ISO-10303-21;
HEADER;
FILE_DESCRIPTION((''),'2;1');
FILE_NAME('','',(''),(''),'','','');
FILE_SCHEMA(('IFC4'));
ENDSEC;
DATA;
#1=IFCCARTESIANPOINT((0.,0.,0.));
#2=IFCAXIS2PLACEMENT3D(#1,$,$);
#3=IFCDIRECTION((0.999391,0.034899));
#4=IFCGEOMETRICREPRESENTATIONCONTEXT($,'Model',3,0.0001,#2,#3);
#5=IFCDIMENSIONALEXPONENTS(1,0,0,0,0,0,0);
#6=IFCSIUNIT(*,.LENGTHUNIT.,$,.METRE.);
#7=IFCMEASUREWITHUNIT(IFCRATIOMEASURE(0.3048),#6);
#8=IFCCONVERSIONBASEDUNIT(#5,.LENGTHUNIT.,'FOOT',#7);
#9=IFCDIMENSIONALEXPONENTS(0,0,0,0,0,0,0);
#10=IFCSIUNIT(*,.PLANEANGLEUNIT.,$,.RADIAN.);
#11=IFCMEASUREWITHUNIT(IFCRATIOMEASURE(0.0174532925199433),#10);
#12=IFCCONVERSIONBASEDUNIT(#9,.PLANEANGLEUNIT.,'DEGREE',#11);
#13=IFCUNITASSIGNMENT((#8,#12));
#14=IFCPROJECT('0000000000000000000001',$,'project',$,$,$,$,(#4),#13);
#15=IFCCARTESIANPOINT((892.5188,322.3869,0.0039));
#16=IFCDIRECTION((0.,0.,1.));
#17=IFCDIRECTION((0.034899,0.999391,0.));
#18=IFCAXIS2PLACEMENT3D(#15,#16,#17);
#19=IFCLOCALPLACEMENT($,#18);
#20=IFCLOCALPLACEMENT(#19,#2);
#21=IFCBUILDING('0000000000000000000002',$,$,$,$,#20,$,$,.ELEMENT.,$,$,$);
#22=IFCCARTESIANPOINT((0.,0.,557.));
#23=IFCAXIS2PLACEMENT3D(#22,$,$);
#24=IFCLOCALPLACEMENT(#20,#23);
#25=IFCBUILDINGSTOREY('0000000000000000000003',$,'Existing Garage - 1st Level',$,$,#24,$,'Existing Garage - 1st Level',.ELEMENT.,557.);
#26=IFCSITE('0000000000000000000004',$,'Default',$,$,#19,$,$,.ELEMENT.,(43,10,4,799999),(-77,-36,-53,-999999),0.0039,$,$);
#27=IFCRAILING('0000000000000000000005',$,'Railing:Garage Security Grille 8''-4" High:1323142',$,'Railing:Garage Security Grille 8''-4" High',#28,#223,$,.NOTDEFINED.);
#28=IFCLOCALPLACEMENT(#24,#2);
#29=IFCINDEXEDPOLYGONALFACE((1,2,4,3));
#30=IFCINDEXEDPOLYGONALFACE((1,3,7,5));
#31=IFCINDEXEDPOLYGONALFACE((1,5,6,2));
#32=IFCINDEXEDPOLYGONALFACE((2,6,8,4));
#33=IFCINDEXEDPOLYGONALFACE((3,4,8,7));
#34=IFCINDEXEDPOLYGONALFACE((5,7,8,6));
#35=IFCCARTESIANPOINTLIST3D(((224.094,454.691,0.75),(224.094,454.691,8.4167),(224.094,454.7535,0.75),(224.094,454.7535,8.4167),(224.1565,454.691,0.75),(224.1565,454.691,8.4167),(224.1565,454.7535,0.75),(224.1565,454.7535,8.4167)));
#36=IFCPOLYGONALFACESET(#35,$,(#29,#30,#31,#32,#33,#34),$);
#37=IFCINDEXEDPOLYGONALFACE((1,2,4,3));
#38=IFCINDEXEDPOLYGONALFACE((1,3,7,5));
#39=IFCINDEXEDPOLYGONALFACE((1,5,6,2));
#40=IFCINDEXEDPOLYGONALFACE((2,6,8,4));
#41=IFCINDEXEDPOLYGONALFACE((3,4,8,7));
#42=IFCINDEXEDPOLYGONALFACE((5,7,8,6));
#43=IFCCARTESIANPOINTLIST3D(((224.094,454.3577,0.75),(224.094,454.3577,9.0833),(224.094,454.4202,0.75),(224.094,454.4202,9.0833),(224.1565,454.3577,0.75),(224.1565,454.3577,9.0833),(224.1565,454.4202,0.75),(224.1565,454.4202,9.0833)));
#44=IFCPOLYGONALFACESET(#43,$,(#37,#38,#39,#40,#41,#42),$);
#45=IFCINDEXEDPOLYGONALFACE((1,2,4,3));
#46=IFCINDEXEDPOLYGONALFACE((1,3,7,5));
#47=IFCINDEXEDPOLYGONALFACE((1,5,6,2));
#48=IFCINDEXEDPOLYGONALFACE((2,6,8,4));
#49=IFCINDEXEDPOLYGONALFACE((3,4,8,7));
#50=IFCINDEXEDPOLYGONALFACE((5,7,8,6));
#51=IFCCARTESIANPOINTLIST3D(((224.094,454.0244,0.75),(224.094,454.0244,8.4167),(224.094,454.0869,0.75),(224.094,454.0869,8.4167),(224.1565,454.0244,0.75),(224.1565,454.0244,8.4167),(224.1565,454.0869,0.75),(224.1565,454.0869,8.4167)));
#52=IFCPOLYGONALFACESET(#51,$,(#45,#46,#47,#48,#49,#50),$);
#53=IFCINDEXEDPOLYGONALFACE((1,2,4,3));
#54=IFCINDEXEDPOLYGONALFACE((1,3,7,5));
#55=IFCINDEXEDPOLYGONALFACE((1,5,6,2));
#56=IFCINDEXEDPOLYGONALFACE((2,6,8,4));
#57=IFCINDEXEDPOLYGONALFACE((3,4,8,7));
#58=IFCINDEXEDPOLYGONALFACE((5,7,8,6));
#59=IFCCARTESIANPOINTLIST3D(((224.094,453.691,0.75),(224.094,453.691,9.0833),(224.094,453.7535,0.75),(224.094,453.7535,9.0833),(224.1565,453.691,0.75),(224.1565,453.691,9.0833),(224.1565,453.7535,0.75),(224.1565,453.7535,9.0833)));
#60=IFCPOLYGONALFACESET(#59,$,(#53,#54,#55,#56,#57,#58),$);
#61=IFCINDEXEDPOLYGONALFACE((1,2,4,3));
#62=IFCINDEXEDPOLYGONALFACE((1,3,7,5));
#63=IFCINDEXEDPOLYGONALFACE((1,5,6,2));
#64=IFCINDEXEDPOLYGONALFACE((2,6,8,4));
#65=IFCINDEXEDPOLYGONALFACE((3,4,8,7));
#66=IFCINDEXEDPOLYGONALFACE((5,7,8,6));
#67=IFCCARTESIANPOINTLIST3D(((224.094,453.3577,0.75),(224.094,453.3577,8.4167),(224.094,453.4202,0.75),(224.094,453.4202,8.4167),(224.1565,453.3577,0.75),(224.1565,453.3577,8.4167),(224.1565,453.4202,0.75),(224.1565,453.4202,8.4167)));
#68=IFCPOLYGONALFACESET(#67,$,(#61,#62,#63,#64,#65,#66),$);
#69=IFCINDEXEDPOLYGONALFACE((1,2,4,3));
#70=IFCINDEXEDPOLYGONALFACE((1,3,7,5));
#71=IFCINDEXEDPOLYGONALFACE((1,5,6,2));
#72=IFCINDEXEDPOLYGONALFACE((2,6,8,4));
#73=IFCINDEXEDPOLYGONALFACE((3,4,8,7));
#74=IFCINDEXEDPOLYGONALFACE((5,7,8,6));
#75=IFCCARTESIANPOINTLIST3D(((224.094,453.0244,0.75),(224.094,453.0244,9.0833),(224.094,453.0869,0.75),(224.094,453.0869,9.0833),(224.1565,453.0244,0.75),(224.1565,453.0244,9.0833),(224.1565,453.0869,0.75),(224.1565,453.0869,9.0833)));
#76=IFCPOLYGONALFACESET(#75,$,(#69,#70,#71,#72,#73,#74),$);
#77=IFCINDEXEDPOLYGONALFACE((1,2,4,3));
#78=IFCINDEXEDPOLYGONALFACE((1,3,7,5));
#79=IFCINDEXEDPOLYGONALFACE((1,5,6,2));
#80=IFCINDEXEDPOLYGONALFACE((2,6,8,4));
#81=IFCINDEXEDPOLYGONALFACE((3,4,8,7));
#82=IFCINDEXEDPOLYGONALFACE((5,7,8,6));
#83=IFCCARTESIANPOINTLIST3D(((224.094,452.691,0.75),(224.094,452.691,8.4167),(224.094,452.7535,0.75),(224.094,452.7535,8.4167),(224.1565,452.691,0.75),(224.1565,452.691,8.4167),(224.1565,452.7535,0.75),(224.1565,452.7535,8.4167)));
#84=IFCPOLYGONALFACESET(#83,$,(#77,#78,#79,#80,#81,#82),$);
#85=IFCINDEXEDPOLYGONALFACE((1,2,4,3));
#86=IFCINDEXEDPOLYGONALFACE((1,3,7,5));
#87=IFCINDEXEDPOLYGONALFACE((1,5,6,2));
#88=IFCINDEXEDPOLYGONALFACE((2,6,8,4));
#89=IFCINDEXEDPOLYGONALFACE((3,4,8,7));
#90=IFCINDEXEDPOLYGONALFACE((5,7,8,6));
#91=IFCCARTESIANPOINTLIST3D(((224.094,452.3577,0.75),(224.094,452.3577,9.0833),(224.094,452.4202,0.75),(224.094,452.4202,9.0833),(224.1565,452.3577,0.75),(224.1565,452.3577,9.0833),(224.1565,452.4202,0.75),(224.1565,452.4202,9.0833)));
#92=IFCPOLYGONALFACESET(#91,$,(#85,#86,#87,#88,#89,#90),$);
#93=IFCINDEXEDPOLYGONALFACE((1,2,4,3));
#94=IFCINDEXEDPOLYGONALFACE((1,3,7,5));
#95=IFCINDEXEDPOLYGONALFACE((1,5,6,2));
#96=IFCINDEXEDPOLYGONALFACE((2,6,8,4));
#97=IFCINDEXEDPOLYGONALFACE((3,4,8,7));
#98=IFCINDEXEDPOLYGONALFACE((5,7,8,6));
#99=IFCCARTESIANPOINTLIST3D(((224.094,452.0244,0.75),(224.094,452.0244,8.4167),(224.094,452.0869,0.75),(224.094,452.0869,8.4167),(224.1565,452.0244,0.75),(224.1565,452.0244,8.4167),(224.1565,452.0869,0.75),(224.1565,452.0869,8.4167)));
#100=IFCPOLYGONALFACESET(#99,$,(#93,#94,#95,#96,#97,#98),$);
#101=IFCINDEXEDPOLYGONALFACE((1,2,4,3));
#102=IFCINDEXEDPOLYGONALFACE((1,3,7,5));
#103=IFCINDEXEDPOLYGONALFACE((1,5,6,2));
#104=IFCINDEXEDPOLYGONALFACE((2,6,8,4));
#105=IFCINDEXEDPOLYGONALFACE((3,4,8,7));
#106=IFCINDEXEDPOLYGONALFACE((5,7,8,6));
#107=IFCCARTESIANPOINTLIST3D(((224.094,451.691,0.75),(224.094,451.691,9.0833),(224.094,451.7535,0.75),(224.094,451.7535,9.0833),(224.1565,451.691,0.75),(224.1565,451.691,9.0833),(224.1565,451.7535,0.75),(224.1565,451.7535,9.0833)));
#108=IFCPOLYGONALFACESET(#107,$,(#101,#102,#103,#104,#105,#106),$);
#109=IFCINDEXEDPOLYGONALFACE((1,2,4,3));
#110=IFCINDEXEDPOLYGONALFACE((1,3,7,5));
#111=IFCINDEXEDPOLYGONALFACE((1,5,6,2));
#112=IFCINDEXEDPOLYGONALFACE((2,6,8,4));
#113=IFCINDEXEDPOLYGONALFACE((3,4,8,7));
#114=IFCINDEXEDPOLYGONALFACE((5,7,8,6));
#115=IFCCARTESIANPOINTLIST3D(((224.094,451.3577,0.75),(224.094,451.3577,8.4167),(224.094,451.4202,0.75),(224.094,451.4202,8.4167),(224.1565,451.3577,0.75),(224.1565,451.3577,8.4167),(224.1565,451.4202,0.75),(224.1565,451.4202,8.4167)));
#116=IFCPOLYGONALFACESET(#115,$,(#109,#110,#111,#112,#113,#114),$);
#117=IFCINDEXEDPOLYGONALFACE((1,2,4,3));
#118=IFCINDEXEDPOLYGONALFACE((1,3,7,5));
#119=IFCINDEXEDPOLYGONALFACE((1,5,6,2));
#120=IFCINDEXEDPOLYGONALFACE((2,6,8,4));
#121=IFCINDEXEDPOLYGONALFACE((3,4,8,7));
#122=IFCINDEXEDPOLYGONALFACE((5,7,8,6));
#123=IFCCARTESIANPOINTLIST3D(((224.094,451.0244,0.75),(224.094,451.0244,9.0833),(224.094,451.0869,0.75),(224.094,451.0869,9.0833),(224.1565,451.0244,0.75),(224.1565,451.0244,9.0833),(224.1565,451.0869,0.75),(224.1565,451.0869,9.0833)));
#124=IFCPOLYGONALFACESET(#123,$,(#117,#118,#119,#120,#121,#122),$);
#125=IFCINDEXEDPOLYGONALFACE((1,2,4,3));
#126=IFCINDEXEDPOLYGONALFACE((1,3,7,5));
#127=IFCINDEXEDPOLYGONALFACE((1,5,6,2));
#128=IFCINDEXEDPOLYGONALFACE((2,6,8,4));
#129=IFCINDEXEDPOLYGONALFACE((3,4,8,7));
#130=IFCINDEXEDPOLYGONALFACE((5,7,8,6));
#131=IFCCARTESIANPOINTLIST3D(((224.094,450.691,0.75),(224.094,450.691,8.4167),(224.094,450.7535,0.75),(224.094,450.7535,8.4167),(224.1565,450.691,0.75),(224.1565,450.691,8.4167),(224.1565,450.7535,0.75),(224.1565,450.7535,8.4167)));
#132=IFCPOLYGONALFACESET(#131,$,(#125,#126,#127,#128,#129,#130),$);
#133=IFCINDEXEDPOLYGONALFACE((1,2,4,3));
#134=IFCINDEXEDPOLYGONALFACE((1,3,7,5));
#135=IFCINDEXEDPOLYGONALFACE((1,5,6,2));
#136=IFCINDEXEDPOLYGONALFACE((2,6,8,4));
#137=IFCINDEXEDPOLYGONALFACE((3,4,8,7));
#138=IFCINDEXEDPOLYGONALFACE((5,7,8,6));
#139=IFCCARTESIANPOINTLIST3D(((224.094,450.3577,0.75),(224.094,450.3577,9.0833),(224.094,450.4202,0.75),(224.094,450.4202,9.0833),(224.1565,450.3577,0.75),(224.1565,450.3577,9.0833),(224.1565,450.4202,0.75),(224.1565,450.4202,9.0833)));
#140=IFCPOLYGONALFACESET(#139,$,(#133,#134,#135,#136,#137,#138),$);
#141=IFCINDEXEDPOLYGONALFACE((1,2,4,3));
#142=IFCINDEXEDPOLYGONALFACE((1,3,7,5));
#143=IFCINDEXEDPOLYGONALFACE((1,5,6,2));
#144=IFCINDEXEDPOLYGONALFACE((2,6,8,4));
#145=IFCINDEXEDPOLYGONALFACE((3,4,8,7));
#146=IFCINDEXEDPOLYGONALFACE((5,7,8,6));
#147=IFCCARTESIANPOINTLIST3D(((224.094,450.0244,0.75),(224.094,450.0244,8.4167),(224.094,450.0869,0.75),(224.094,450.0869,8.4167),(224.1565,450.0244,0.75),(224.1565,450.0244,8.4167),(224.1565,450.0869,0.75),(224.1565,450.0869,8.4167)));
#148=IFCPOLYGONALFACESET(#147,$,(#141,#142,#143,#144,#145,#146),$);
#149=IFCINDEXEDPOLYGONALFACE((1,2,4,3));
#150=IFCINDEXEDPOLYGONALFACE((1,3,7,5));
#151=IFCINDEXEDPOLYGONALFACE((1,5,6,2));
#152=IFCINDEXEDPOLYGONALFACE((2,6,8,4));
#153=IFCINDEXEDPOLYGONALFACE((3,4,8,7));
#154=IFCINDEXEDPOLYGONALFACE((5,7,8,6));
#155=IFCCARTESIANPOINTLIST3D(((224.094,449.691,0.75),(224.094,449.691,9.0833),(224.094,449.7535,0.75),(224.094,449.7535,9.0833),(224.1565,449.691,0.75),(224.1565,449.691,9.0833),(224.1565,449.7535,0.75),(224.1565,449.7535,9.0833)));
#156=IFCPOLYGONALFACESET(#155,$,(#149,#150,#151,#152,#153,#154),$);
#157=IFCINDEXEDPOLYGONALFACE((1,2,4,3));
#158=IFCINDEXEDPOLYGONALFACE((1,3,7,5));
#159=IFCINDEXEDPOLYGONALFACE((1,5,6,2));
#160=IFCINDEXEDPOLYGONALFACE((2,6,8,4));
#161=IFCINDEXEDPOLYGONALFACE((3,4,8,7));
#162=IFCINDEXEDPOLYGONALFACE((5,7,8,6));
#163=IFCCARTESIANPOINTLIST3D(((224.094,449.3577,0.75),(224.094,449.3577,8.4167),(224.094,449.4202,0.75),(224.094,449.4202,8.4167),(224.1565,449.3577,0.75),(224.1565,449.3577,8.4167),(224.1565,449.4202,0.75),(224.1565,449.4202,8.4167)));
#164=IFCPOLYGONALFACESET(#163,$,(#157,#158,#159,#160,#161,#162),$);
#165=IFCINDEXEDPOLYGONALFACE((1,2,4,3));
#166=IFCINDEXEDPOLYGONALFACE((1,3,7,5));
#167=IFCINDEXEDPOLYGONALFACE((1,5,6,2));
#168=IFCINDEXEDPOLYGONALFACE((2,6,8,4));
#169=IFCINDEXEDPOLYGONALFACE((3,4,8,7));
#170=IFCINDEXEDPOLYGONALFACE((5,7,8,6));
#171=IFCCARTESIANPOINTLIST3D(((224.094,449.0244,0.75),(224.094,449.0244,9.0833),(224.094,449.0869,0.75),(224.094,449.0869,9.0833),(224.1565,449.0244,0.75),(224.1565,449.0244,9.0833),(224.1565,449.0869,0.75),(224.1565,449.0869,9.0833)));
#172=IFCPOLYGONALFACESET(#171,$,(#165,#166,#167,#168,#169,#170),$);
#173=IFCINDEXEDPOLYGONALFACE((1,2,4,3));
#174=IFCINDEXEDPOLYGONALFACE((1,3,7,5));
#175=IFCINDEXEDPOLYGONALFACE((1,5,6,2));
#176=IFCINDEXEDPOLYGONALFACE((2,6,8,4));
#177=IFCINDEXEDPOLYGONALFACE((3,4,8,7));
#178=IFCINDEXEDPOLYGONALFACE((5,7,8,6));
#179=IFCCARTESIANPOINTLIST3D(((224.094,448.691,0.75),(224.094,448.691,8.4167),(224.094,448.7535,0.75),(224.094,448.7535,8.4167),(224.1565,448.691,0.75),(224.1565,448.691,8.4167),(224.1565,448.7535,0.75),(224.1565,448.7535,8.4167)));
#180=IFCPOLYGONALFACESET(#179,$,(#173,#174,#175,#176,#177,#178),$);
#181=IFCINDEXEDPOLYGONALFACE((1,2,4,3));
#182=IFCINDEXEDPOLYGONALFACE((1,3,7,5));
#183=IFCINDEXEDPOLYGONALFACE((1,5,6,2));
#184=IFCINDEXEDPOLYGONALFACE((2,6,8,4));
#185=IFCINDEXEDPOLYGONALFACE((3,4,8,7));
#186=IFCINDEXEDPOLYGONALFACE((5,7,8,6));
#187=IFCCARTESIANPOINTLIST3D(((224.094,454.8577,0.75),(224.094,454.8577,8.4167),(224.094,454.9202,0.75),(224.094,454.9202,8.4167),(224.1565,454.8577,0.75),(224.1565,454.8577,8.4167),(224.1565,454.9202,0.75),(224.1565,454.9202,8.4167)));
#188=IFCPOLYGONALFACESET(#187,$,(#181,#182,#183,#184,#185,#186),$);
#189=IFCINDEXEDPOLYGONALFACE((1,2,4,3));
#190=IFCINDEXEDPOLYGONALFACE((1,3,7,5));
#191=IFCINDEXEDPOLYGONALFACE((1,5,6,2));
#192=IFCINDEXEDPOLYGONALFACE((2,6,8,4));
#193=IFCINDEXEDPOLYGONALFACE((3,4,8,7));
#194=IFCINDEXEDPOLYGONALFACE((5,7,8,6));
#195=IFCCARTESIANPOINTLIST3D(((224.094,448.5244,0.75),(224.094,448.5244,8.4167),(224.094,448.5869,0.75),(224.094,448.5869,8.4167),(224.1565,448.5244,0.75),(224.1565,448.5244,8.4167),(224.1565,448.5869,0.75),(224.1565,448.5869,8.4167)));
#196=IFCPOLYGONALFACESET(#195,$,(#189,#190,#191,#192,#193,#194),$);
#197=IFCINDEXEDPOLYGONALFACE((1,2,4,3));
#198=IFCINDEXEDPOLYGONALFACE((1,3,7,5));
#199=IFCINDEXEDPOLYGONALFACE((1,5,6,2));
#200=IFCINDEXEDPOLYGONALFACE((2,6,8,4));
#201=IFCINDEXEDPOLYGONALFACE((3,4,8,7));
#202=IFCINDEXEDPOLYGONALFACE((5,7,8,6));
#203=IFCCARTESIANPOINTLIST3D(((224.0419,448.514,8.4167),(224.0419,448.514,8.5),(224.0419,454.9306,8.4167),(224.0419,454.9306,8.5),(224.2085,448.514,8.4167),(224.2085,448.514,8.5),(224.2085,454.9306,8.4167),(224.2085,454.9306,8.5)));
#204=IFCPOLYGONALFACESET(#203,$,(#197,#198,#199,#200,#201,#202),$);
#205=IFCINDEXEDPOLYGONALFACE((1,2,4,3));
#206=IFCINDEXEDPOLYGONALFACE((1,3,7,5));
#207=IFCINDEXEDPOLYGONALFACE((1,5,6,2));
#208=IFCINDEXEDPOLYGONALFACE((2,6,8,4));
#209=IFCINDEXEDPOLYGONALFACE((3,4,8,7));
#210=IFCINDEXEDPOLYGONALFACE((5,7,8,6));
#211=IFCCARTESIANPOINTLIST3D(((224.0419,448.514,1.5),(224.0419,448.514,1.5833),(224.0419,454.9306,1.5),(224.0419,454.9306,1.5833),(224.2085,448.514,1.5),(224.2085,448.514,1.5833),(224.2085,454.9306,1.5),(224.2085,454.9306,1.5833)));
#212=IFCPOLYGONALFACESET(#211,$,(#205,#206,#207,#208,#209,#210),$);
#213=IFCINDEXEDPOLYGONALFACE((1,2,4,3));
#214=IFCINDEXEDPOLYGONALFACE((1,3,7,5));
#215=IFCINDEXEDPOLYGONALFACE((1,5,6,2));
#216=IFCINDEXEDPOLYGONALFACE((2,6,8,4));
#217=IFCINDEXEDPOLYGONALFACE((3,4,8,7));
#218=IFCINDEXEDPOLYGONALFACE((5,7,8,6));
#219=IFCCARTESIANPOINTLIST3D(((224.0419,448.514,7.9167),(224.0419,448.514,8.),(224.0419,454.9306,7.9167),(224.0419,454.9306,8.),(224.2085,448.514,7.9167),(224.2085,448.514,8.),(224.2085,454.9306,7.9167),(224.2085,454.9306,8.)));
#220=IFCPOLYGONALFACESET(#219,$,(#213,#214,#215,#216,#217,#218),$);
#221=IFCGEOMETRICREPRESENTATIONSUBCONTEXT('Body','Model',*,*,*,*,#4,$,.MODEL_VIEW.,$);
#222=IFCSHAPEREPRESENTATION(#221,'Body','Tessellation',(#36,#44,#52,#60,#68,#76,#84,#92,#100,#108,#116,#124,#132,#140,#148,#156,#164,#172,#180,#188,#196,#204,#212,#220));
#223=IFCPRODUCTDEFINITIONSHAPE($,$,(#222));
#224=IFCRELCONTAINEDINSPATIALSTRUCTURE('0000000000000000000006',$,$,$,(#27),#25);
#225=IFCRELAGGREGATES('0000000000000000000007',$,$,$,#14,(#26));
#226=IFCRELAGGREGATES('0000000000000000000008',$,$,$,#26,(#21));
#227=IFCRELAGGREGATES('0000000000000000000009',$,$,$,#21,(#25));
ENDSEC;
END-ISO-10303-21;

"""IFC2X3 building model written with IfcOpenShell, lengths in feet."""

from ifc_helpers import new_model, entity, si_unit, converted_unit, direction, frame, frame_2d, origin, origin_2d_with_axis, place, context, subcontext, project, spatial, rectangle, extrude, element, save


model = new_model("IFC2X3")

# Units and contexts
model_context = context("Model", 3, precision=0.0001, world=origin(), true_north=direction((0.999391, 0.034899)))
body_context = subcontext(model_context, "Body", "Model", "MODEL_VIEW")
ifc_project = project(units=[converted_unit("LENGTHUNIT", "FOOT", entity("IfcRatioMeasure", 0.3048), si_unit("LENGTHUNIT", "METRE"), dimensions=[1, 0, 0, 0, 0, 0, 0]), converted_unit("PLANEANGLEUNIT", "DEGREE", entity("IfcRatioMeasure", 0.0174532925199433), si_unit("PLANEANGLEUNIT", "RADIAN"), dimensions=[0, 0, 0, 0, 0, 0, 0])], contexts=[model_context])

# Site, building, storey
site_placement = place(None, frame((892.5188, 322.3869, 0.0039), z_axis=(0.0, 0.0, 1.0), x_axis=(0.034899, 0.999391, 0.0)))
site = spatial("IfcSite", under=ifc_project, at=site_placement, Name="Default", CompositionType="ELEMENT", RefLatitude=(43, 10, 4, 799999), RefLongitude=(-77, -36, -53, -999999), RefElevation=0.0039)
building_placement = place(site_placement, origin())
building = spatial("IfcBuilding", under=site, at=building_placement, CompositionType="ELEMENT")
storey_placement = place(building_placement, frame((0.0, 0.0, 557.0)))
storey = spatial("IfcBuildingStorey", under=building, at=storey_placement, Name="Existing Garage - 1st Level", LongName="Existing Garage - 1st Level", CompositionType="ELEMENT", Elevation=557.0)

# Railing
railing_1_placement = place(storey_placement, origin())
element("IfcRailing", 1, at=railing_1_placement, inside=storey, Name="Railing:Garage Security Grille 8'-4\" High:1323142", ObjectType="Railing:Garage Security Grille 8'-4\" High", PredefinedType="NOTDEFINED", context=body_context, shape_type="SweptSolid", body=[
    extrude(rectangle(XDim=0.0625, YDim=0.0625, at=origin_2d_with_axis()), frame((224.1252, 454.7223, 0.75), z_axis=(0.0, 0.0, 1.0), x_axis=(0.0, 1.0, 0.0)), (0.0, 0.0, 1.0), 7.6667),
    extrude(rectangle(XDim=0.0625, YDim=0.0625, at=origin_2d_with_axis()), frame((224.1252, 454.389, 0.75), z_axis=(0.0, 0.0, 1.0), x_axis=(0.0, 1.0, 0.0)), (0.0, 0.0, 1.0), 8.3333),
    extrude(rectangle(XDim=0.0625, YDim=0.0625, at=origin_2d_with_axis()), frame((224.1252, 454.0556, 0.75), z_axis=(0.0, 0.0, 1.0), x_axis=(0.0, 1.0, 0.0)), (0.0, 0.0, 1.0), 7.6667),
    extrude(rectangle(XDim=0.0625, YDim=0.0625, at=origin_2d_with_axis()), frame((224.1252, 453.7223, 0.75), z_axis=(0.0, 0.0, 1.0), x_axis=(0.0, 1.0, 0.0)), (0.0, 0.0, 1.0), 8.3333),
    extrude(rectangle(XDim=0.0625, YDim=0.0625, at=origin_2d_with_axis()), frame((224.1252, 453.389, 0.75), z_axis=(0.0, 0.0, 1.0), x_axis=(0.0, 1.0, 0.0)), (0.0, 0.0, 1.0), 7.6667),
    extrude(rectangle(XDim=0.0625, YDim=0.0625, at=origin_2d_with_axis()), frame((224.1252, 453.0556, 0.75), z_axis=(0.0, 0.0, 1.0), x_axis=(0.0, 1.0, 0.0)), (0.0, 0.0, 1.0), 8.3333),
    extrude(rectangle(XDim=0.0625, YDim=0.0625, at=origin_2d_with_axis()), frame((224.1252, 452.7223, 0.75), z_axis=(0.0, 0.0, 1.0), x_axis=(0.0, 1.0, 0.0)), (0.0, 0.0, 1.0), 7.6667),
    extrude(rectangle(XDim=0.0625, YDim=0.0625, at=origin_2d_with_axis()), frame((224.1252, 452.389, 0.75), z_axis=(0.0, 0.0, 1.0), x_axis=(0.0, 1.0, 0.0)), (0.0, 0.0, 1.0), 8.3333),
    extrude(rectangle(XDim=0.0625, YDim=0.0625, at=origin_2d_with_axis()), frame((224.1252, 452.0556, 0.75), z_axis=(0.0, 0.0, 1.0), x_axis=(0.0, 1.0, 0.0)), (0.0, 0.0, 1.0), 7.6667),
    extrude(rectangle(XDim=0.0625, YDim=0.0625, at=origin_2d_with_axis()), frame((224.1252, 451.7223, 0.75), z_axis=(0.0, 0.0, 1.0), x_axis=(0.0, 1.0, 0.0)), (0.0, 0.0, 1.0), 8.3333),
    extrude(rectangle(XDim=0.0625, YDim=0.0625, at=origin_2d_with_axis()), frame((224.1252, 451.389, 0.75), z_axis=(0.0, 0.0, 1.0), x_axis=(0.0, 1.0, 0.0)), (0.0, 0.0, 1.0), 7.6667),
    extrude(rectangle(XDim=0.0625, YDim=0.0625, at=origin_2d_with_axis()), frame((224.1252, 451.0556, 0.75), z_axis=(0.0, 0.0, 1.0), x_axis=(0.0, 1.0, 0.0)), (0.0, 0.0, 1.0), 8.3333),
    extrude(rectangle(XDim=0.0625, YDim=0.0625, at=origin_2d_with_axis()), frame((224.1252, 450.7223, 0.75), z_axis=(0.0, 0.0, 1.0), x_axis=(0.0, 1.0, 0.0)), (0.0, 0.0, 1.0), 7.6667),
    extrude(rectangle(XDim=0.0625, YDim=0.0625, at=origin_2d_with_axis()), frame((224.1252, 450.389, 0.75), z_axis=(0.0, 0.0, 1.0), x_axis=(0.0, 1.0, 0.0)), (0.0, 0.0, 1.0), 8.3333),
    extrude(rectangle(XDim=0.0625, YDim=0.0625, at=origin_2d_with_axis()), frame((224.1252, 450.0556, 0.75), z_axis=(0.0, 0.0, 1.0), x_axis=(0.0, 1.0, 0.0)), (0.0, 0.0, 1.0), 7.6667),
    extrude(rectangle(XDim=0.0625, YDim=0.0625, at=origin_2d_with_axis()), frame((224.1252, 449.7223, 0.75), z_axis=(0.0, 0.0, 1.0), x_axis=(0.0, 1.0, 0.0)), (0.0, 0.0, 1.0), 8.3333),
    extrude(rectangle(XDim=0.0625, YDim=0.0625, at=origin_2d_with_axis()), frame((224.1252, 449.389, 0.75), z_axis=(0.0, 0.0, 1.0), x_axis=(0.0, 1.0, 0.0)), (0.0, 0.0, 1.0), 7.6667),
    extrude(rectangle(XDim=0.0625, YDim=0.0625, at=origin_2d_with_axis()), frame((224.1252, 449.0556, 0.75), z_axis=(0.0, 0.0, 1.0), x_axis=(0.0, 1.0, 0.0)), (0.0, 0.0, 1.0), 8.3333),
    extrude(rectangle(XDim=0.0625, YDim=0.0625, at=origin_2d_with_axis()), frame((224.1252, 448.7223, 0.75), z_axis=(0.0, 0.0, 1.0), x_axis=(0.0, 1.0, 0.0)), (0.0, 0.0, 1.0), 7.6667),
    extrude(rectangle(XDim=0.0625, YDim=0.0625, at=origin_2d_with_axis()), frame((224.1252, 454.889, 0.75), z_axis=(0.0, 0.0, 1.0), x_axis=(0.0, 1.0, 0.0)), (0.0, 0.0, 1.0), 7.6667),
    extrude(rectangle(XDim=0.0625, YDim=0.0625, at=origin_2d_with_axis()), frame((224.1252, 448.5556, 0.75), z_axis=(0.0, 0.0, 1.0), x_axis=(0.0, 1.0, 0.0)), (0.0, 0.0, 1.0), 7.6667),
    extrude(rectangle(XDim=6.4167, YDim=0.1667, at=frame_2d((0.0, 0.0), x_axis=(1.0, 0.0))), frame((224.1252, 451.7223, 8.4167), z_axis=(0.0, 0.0, 1.0), x_axis=(0.0, 1.0, 0.0)), (0.0, 0.0, 1.0), 0.0833),
    extrude(rectangle(XDim=6.4167, YDim=0.1667, at=frame_2d((0.0, 0.0), x_axis=(1.0, 0.0))), frame((224.1252, 451.7223, 1.5), z_axis=(0.0, 0.0, 1.0), x_axis=(0.0, 1.0, 0.0)), (0.0, 0.0, 1.0), 0.0833),
    extrude(rectangle(XDim=6.4167, YDim=0.1667, at=frame_2d((0.0, 0.0), x_axis=(1.0, 0.0))), frame((224.1252, 451.7223, 7.9167), z_axis=(0.0, 0.0, 1.0), x_axis=(0.0, 1.0, 0.0)), (0.0, 0.0, 1.0), 0.0833),
])

save(model, "model.ifc")
